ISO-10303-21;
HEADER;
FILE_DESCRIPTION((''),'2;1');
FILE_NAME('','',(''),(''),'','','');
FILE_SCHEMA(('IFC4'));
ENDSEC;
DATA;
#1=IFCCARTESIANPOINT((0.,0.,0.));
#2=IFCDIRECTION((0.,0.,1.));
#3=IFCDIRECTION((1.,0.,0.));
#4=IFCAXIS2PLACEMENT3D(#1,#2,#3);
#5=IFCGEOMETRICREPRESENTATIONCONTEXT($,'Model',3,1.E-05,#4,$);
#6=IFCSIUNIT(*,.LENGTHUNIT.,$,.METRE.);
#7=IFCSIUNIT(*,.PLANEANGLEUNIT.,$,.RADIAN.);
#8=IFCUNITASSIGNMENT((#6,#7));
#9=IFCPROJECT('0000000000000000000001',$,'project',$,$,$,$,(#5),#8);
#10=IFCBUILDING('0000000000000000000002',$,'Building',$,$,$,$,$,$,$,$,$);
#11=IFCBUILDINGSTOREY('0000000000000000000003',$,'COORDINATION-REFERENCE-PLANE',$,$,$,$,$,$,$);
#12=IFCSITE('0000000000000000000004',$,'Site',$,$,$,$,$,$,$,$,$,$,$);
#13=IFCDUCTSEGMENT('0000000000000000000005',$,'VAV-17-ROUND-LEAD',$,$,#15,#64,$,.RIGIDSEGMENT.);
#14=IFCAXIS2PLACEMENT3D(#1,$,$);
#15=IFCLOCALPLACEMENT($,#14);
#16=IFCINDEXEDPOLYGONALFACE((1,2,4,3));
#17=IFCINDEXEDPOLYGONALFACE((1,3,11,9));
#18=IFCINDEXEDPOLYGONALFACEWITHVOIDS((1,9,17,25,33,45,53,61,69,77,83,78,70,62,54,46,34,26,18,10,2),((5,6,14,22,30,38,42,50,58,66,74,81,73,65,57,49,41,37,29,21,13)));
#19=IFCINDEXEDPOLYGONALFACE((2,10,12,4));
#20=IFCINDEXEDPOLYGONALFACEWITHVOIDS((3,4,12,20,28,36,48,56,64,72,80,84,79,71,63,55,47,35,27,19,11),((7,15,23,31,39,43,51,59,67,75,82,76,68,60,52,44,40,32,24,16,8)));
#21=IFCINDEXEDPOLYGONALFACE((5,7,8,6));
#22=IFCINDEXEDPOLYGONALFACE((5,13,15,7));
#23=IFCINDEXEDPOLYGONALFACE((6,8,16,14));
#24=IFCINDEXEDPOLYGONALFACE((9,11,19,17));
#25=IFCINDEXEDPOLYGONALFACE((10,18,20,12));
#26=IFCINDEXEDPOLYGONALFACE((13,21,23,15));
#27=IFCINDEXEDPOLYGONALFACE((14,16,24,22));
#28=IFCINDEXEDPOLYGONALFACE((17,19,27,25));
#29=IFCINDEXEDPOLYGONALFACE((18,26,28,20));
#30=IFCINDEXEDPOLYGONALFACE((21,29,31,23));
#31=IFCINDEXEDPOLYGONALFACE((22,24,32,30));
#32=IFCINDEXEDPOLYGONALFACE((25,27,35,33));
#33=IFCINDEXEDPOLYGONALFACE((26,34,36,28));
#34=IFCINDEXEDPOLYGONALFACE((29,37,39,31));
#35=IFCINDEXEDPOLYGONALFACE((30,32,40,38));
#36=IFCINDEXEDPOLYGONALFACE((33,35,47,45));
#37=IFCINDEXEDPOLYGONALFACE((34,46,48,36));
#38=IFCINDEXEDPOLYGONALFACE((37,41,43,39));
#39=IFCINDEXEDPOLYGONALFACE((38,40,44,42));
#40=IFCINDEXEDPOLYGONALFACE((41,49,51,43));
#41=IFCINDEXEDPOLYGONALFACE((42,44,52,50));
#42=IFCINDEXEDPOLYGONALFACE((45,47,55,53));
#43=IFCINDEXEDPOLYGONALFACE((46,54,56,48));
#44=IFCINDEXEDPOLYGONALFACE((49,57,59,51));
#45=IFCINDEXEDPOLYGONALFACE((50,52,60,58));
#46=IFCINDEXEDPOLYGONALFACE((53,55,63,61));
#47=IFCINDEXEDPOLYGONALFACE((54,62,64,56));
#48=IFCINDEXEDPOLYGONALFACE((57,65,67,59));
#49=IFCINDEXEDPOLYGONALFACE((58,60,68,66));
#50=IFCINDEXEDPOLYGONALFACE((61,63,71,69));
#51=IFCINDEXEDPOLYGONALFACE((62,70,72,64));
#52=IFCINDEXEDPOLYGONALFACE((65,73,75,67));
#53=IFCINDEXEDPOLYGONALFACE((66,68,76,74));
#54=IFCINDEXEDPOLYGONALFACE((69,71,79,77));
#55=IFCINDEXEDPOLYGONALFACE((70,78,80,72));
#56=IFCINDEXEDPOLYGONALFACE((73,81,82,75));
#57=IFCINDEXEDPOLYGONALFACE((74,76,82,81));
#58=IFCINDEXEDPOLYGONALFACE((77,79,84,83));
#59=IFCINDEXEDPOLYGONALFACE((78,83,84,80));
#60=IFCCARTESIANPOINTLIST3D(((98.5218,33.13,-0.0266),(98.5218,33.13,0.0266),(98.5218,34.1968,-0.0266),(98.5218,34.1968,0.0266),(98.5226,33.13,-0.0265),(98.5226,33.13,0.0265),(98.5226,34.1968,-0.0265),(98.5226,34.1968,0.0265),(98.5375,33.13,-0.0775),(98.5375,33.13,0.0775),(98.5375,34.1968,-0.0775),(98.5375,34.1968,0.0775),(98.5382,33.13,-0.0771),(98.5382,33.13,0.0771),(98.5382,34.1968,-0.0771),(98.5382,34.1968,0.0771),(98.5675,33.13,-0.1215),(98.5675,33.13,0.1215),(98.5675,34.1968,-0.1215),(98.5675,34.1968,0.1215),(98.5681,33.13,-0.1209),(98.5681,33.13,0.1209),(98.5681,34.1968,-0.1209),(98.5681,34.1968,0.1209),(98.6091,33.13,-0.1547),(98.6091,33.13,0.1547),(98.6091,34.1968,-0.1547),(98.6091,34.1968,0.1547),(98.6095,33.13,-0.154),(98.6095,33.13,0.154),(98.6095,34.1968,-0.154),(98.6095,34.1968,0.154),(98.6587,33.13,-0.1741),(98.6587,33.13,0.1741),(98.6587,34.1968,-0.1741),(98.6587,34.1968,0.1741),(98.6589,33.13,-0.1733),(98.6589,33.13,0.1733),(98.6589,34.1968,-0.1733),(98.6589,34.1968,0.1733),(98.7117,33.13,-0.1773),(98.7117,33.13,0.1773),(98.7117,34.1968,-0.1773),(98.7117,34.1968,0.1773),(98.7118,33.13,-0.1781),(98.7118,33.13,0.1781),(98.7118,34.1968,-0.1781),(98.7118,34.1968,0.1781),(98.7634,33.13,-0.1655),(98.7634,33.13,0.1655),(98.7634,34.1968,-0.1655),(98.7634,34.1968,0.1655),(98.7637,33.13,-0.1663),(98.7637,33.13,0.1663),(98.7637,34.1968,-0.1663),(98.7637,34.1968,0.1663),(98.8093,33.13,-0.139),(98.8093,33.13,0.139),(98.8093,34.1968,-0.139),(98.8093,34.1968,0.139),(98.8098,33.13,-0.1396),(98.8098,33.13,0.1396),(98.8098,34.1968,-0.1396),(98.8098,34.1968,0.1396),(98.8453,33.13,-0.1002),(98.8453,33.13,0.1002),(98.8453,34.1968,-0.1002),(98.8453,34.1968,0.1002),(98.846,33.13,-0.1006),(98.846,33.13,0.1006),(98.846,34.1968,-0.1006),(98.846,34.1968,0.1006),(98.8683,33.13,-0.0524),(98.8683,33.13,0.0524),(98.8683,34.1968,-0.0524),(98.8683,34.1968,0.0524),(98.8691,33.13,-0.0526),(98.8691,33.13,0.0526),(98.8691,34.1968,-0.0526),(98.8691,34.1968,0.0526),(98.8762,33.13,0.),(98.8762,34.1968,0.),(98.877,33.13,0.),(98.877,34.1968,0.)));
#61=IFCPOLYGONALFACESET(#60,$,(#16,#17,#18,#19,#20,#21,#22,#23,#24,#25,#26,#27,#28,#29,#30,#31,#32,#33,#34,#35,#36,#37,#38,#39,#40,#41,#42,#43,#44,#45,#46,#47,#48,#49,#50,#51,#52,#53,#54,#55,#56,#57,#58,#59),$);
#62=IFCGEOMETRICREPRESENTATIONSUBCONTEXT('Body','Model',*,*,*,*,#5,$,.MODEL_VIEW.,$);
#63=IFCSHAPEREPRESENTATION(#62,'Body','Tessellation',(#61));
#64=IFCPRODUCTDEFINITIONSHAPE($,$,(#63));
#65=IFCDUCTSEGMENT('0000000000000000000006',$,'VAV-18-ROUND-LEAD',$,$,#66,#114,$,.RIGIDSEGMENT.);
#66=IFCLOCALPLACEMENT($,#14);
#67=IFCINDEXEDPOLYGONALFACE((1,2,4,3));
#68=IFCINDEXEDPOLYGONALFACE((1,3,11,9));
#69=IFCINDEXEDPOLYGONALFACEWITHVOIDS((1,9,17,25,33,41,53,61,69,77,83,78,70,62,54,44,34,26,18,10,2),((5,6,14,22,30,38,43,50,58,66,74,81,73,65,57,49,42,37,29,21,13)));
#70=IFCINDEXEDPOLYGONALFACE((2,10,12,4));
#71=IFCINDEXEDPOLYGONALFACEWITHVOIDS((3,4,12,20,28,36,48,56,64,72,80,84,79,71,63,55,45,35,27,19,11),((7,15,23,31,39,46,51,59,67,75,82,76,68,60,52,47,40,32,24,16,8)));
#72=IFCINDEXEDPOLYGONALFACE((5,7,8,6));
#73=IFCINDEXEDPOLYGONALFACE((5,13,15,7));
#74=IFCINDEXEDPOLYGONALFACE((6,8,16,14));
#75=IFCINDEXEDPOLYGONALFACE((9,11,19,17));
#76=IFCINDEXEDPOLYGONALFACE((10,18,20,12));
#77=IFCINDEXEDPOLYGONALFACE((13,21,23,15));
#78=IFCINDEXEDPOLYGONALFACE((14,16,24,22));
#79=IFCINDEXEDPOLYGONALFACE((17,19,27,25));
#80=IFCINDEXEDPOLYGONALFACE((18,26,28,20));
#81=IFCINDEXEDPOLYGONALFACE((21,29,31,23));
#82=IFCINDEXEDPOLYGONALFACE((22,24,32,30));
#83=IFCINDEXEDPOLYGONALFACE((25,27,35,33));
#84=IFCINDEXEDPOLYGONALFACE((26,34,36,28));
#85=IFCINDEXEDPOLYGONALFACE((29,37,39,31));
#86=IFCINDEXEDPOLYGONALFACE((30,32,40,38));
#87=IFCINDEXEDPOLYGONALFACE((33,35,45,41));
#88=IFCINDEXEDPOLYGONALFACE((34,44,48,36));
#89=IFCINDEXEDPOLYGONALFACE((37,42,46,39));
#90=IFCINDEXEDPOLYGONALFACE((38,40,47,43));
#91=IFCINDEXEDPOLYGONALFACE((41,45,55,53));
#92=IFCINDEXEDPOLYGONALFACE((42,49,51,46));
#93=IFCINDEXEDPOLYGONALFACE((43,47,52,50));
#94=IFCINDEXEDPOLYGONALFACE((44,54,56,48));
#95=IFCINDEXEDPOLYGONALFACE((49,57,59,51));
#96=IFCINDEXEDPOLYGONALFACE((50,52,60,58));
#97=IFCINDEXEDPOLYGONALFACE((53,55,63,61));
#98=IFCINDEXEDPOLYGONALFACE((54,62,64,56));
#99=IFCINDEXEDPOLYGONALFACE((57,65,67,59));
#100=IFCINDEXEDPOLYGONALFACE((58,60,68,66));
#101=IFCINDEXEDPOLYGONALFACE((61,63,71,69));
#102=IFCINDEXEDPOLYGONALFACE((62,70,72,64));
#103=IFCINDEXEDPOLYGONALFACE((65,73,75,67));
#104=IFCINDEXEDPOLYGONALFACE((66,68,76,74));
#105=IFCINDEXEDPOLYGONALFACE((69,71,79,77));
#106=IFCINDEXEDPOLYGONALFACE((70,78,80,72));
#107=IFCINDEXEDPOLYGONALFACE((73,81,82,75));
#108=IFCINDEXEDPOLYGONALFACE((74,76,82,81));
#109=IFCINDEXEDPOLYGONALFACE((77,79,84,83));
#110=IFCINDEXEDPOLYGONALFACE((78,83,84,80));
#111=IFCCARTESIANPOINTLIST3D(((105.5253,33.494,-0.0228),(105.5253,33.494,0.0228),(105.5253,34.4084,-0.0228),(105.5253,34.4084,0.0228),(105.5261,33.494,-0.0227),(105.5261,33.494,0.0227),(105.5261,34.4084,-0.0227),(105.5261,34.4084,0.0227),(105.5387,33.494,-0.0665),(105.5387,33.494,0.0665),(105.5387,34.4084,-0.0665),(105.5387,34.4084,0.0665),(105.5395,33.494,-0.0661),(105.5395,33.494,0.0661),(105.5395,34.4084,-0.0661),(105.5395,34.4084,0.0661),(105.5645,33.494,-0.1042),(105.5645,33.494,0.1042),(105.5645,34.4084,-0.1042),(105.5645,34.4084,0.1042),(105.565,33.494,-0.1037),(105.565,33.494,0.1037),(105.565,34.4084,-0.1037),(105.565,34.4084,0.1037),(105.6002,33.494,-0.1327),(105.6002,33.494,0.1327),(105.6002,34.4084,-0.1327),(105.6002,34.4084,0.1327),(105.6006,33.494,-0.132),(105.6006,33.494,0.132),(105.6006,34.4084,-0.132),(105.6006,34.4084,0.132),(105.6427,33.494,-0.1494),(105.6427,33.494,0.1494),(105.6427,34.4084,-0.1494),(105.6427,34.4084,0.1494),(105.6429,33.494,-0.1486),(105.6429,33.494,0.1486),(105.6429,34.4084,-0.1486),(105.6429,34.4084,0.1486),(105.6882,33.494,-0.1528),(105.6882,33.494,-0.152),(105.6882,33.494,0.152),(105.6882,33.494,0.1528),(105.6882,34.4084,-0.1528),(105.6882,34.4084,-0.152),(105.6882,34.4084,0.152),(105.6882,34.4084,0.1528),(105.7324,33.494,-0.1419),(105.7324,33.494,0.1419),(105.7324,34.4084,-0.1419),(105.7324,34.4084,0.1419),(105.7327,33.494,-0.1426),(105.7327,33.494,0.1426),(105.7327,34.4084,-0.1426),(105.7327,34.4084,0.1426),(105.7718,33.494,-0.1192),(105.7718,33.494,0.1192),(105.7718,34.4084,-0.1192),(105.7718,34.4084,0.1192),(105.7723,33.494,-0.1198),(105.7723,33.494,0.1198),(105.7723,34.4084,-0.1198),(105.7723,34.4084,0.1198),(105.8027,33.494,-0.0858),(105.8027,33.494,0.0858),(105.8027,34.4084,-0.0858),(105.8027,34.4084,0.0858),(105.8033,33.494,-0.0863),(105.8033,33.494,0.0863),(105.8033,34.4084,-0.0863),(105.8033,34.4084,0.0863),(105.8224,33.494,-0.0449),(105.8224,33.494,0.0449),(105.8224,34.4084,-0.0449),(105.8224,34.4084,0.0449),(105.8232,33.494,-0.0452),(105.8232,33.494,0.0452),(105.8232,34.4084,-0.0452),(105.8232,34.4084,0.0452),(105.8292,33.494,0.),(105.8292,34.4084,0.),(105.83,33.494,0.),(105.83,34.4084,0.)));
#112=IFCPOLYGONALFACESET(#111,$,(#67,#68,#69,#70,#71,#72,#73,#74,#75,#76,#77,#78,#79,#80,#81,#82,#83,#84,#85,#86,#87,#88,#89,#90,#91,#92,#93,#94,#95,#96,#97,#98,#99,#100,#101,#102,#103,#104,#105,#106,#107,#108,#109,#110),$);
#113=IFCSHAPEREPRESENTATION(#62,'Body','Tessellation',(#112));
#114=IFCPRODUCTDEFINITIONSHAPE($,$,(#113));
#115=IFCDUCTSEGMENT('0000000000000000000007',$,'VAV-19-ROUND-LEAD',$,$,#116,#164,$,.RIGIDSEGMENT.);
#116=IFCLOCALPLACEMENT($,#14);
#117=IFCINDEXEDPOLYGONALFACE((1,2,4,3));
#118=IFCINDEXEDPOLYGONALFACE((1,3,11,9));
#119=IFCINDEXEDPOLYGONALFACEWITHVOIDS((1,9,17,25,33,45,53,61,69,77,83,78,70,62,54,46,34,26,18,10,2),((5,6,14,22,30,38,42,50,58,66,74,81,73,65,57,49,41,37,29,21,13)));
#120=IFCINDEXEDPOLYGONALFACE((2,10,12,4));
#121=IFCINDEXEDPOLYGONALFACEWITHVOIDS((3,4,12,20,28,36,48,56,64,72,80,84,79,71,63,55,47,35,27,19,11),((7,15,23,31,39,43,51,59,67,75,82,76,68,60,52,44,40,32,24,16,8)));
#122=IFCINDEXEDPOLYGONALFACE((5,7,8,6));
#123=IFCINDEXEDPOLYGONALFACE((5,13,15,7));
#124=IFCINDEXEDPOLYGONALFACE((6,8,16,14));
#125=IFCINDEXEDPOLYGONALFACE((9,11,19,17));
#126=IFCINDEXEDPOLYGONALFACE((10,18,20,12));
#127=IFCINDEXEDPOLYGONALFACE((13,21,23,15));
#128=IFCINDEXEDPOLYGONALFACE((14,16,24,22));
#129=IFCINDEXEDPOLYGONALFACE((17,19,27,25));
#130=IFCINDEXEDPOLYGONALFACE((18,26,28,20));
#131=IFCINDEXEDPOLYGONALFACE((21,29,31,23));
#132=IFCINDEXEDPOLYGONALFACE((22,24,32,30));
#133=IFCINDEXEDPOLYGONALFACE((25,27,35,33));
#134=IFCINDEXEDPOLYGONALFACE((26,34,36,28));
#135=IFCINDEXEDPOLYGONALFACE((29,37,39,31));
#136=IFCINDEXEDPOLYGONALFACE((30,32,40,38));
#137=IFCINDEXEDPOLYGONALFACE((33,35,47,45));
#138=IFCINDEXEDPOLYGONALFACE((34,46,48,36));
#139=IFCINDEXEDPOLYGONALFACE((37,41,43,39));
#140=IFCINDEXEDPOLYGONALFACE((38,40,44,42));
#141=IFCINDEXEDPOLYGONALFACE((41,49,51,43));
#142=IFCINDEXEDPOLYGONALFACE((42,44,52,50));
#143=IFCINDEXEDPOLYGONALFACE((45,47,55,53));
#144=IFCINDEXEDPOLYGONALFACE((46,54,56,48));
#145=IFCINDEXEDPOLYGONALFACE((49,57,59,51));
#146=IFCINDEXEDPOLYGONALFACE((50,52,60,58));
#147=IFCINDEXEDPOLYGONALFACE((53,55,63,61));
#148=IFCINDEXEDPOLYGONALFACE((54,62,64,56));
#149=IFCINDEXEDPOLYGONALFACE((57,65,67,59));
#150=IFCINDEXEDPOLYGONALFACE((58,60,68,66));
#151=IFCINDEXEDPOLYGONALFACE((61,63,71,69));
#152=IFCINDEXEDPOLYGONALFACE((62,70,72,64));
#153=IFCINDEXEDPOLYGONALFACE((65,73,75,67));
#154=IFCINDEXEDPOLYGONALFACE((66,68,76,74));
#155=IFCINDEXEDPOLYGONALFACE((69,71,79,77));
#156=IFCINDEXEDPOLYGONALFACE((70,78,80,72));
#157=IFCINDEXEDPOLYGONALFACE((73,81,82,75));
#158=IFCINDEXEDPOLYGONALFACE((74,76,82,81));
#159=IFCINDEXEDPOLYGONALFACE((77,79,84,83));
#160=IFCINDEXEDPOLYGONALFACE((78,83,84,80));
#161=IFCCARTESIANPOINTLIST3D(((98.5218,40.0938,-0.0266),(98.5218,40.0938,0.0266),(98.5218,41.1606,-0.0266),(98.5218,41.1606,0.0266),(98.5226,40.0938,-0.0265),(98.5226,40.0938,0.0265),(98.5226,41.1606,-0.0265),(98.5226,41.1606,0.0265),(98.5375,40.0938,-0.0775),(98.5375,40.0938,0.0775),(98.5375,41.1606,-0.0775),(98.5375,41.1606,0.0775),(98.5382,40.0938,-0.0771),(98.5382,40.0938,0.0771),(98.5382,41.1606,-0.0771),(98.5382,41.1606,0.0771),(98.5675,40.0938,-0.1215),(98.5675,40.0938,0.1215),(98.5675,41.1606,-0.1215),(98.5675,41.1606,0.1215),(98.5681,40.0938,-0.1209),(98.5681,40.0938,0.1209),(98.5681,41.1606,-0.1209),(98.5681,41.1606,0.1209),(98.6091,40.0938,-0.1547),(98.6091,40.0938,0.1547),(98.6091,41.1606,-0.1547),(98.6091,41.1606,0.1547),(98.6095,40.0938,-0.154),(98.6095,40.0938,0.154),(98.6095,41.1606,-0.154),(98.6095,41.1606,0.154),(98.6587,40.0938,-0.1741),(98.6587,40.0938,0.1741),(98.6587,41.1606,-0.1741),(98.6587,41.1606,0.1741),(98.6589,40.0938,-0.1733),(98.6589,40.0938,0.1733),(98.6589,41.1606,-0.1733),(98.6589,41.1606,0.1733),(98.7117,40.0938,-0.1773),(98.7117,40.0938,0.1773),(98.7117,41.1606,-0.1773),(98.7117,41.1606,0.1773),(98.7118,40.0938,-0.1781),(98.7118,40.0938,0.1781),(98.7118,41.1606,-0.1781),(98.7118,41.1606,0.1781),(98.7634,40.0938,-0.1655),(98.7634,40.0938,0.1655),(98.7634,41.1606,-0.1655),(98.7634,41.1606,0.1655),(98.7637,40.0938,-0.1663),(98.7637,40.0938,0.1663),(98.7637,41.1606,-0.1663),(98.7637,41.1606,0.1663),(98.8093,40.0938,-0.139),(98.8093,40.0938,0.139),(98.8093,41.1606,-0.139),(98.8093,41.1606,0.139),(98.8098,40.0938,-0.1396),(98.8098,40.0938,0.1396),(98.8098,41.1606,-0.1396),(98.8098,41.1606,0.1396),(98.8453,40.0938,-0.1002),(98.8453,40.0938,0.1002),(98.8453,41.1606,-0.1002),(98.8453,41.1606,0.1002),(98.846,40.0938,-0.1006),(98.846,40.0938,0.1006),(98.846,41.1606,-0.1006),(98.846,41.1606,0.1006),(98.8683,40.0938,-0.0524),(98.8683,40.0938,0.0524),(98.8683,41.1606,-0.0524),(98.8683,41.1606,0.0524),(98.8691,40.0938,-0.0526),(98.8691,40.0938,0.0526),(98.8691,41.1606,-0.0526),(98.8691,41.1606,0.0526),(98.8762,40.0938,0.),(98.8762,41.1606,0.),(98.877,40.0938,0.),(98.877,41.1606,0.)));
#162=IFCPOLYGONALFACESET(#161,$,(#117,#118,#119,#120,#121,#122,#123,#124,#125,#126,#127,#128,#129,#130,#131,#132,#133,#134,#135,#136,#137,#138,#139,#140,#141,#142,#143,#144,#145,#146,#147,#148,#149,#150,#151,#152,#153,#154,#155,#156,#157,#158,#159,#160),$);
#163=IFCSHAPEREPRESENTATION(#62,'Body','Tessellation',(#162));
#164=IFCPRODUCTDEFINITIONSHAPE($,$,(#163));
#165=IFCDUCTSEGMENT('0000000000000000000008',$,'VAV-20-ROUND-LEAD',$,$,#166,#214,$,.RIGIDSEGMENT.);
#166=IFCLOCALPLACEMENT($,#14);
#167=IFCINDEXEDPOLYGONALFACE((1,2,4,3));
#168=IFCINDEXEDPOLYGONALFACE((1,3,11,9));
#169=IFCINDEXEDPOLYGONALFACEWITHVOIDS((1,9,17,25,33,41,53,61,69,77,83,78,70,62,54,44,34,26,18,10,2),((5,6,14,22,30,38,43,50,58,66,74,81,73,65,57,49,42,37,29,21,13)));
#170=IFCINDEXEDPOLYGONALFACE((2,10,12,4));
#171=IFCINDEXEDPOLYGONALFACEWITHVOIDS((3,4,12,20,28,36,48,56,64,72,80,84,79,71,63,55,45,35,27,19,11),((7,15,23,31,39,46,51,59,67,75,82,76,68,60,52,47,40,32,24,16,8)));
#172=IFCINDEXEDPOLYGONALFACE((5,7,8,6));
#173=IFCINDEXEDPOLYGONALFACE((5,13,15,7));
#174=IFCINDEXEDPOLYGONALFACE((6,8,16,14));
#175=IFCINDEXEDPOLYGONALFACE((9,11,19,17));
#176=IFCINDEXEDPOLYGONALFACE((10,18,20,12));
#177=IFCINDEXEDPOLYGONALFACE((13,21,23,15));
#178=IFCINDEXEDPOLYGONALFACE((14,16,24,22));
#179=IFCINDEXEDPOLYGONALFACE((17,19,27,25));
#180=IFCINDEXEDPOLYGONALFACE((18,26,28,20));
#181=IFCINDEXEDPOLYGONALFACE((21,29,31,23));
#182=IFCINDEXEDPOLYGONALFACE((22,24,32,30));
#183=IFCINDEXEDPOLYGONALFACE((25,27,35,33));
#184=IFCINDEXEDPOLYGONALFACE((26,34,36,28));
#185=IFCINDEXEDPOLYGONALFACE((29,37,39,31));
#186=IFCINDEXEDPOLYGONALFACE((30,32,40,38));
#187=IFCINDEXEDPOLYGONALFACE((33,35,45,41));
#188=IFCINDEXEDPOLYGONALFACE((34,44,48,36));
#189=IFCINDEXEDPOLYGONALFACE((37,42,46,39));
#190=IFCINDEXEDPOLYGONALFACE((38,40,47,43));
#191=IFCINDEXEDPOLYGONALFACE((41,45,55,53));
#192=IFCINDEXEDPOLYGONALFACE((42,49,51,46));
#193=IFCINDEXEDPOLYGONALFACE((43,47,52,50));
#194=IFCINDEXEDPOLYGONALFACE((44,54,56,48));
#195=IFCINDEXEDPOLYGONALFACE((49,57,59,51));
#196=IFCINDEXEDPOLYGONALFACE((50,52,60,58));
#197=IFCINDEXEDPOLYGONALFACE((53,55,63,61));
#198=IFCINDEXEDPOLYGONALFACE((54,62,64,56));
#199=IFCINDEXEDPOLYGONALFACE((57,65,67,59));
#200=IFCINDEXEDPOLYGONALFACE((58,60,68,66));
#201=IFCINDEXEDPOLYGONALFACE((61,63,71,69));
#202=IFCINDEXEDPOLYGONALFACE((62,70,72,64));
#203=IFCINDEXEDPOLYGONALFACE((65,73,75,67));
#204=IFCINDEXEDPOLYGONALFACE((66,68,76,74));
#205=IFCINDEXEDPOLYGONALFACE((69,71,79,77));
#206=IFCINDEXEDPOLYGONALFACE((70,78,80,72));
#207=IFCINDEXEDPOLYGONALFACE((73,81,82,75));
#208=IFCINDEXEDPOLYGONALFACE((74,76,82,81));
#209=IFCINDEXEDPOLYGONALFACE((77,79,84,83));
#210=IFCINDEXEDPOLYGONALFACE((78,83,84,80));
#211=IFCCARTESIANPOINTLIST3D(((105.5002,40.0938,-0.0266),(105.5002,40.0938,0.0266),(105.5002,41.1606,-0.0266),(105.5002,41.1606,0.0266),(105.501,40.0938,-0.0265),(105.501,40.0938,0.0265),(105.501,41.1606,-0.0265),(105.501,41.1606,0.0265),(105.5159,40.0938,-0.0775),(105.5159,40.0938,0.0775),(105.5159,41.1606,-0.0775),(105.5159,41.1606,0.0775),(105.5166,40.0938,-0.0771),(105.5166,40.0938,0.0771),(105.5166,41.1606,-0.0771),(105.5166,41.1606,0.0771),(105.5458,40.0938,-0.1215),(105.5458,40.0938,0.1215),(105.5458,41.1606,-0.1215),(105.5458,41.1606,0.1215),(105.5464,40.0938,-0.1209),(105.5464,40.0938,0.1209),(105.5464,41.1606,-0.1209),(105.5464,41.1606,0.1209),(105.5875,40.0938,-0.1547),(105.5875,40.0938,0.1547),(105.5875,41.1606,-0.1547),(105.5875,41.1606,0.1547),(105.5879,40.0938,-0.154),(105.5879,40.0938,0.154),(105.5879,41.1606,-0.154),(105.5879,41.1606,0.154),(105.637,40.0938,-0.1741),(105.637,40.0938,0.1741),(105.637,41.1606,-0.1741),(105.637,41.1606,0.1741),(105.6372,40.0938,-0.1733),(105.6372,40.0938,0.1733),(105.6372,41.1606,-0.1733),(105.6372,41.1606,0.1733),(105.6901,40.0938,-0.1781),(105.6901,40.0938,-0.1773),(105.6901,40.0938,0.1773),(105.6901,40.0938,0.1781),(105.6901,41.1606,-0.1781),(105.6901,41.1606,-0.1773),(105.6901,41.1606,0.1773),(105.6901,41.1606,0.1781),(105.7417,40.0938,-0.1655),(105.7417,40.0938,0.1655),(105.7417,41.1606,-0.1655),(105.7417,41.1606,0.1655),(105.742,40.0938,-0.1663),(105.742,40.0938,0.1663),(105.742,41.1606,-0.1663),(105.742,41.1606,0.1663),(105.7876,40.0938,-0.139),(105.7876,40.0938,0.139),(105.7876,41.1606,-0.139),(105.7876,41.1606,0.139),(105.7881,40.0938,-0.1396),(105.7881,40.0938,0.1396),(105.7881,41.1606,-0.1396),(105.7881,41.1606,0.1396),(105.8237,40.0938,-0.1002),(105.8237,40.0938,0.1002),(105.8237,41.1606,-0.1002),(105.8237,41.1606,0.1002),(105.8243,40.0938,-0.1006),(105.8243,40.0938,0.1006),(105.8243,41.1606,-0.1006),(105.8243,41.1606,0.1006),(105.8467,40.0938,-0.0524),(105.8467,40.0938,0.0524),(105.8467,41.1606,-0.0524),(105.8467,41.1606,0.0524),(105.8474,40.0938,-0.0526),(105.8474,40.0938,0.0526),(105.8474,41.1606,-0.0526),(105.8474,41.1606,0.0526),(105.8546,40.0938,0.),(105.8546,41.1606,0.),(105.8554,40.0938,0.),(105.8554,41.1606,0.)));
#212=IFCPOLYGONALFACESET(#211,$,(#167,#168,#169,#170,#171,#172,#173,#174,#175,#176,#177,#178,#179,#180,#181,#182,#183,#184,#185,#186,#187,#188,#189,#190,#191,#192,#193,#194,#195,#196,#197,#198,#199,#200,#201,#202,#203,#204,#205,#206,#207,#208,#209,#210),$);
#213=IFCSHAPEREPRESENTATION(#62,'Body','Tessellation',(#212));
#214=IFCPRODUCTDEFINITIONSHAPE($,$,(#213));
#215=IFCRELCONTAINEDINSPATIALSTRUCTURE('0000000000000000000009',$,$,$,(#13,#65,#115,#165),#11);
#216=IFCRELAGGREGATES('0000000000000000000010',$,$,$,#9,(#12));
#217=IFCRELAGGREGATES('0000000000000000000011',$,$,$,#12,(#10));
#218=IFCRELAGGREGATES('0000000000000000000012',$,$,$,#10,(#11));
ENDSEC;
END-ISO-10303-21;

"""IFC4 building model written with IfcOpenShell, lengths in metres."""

from ifc_helpers import new_model, si_unit, frame, origin, origin_with_axes, place, context, subcontext, project, spatial, hollow_circle, extrude, element, save


model = new_model("IFC4")

# Units and contexts
model_context = context("Model", 3, precision=1e-05, world=origin_with_axes())
body_context_1 = subcontext(model_context, "Body", "Model", "MODEL_VIEW")
ifc_project = project(units=[si_unit("LENGTHUNIT", "METRE"), si_unit("PLANEANGLEUNIT", "RADIAN")], contexts=[model_context])

# Site, building, storey
site = spatial("IfcSite", under=ifc_project, Name="Site")
building = spatial("IfcBuilding", under=site, Name="Building")
storey = spatial("IfcBuildingStorey", under=building, Name="COORDINATION-REFERENCE-PLANE")

# Duct segments
for number, where, z_axis, x_axis, name in (
    (1, (98.6984, 34.1968, 0.0), (0.0, -1.0, 0.0), (1.0, 0.0, 0.0), "VAV-17-ROUND-LEAD"),
):
    element("IfcDuctSegment", number, at=place(None, frame(where, z_axis=z_axis, x_axis=x_axis)), inside=storey, Name=name, PredefinedType="RIGIDSEGMENT", context=body_context_1, shape_type="SweptSolid", body=[
        extrude(hollow_circle(Radius=0.1786, WallThickness=0.0008), origin(), (0.0, 0.0, 1.0), 1.0668),
    ])
duct_segment_1_placement = place(None, frame((105.6768, 34.4084, 0.0), z_axis=(0.0, -1.0, 0.0), x_axis=(1.0, 0.0, 0.0)))
element("IfcDuctSegment", 2, at=duct_segment_1_placement, inside=storey, Name="VAV-18-ROUND-LEAD", PredefinedType="RIGIDSEGMENT", context=body_context_1, shape_type="SweptSolid", body=[
    extrude(hollow_circle(Radius=0.1532, WallThickness=0.0008), origin(), (0.0, 0.0, 1.0), 0.9144),
])
for number, where, z_axis, x_axis, name in (
    (3, (98.6984, 40.0938, 0.0), (0.0, 1.0, 0.0), (1.0, 0.0, 0.0), "VAV-19-ROUND-LEAD"),
    (4, (105.6768, 40.0938, 0.0), (0.0, 1.0, 0.0), (1.0, 0.0, 0.0), "VAV-20-ROUND-LEAD"),
):
    element("IfcDuctSegment", number, at=place(None, frame(where, z_axis=z_axis, x_axis=x_axis)), inside=storey, Name=name, PredefinedType="RIGIDSEGMENT", context=body_context_1, shape_type="SweptSolid", body=[
        extrude(hollow_circle(Radius=0.1786, WallThickness=0.0008), origin(), (0.0, 0.0, 1.0), 1.0668),
    ])

save(model, "model.ifc")
